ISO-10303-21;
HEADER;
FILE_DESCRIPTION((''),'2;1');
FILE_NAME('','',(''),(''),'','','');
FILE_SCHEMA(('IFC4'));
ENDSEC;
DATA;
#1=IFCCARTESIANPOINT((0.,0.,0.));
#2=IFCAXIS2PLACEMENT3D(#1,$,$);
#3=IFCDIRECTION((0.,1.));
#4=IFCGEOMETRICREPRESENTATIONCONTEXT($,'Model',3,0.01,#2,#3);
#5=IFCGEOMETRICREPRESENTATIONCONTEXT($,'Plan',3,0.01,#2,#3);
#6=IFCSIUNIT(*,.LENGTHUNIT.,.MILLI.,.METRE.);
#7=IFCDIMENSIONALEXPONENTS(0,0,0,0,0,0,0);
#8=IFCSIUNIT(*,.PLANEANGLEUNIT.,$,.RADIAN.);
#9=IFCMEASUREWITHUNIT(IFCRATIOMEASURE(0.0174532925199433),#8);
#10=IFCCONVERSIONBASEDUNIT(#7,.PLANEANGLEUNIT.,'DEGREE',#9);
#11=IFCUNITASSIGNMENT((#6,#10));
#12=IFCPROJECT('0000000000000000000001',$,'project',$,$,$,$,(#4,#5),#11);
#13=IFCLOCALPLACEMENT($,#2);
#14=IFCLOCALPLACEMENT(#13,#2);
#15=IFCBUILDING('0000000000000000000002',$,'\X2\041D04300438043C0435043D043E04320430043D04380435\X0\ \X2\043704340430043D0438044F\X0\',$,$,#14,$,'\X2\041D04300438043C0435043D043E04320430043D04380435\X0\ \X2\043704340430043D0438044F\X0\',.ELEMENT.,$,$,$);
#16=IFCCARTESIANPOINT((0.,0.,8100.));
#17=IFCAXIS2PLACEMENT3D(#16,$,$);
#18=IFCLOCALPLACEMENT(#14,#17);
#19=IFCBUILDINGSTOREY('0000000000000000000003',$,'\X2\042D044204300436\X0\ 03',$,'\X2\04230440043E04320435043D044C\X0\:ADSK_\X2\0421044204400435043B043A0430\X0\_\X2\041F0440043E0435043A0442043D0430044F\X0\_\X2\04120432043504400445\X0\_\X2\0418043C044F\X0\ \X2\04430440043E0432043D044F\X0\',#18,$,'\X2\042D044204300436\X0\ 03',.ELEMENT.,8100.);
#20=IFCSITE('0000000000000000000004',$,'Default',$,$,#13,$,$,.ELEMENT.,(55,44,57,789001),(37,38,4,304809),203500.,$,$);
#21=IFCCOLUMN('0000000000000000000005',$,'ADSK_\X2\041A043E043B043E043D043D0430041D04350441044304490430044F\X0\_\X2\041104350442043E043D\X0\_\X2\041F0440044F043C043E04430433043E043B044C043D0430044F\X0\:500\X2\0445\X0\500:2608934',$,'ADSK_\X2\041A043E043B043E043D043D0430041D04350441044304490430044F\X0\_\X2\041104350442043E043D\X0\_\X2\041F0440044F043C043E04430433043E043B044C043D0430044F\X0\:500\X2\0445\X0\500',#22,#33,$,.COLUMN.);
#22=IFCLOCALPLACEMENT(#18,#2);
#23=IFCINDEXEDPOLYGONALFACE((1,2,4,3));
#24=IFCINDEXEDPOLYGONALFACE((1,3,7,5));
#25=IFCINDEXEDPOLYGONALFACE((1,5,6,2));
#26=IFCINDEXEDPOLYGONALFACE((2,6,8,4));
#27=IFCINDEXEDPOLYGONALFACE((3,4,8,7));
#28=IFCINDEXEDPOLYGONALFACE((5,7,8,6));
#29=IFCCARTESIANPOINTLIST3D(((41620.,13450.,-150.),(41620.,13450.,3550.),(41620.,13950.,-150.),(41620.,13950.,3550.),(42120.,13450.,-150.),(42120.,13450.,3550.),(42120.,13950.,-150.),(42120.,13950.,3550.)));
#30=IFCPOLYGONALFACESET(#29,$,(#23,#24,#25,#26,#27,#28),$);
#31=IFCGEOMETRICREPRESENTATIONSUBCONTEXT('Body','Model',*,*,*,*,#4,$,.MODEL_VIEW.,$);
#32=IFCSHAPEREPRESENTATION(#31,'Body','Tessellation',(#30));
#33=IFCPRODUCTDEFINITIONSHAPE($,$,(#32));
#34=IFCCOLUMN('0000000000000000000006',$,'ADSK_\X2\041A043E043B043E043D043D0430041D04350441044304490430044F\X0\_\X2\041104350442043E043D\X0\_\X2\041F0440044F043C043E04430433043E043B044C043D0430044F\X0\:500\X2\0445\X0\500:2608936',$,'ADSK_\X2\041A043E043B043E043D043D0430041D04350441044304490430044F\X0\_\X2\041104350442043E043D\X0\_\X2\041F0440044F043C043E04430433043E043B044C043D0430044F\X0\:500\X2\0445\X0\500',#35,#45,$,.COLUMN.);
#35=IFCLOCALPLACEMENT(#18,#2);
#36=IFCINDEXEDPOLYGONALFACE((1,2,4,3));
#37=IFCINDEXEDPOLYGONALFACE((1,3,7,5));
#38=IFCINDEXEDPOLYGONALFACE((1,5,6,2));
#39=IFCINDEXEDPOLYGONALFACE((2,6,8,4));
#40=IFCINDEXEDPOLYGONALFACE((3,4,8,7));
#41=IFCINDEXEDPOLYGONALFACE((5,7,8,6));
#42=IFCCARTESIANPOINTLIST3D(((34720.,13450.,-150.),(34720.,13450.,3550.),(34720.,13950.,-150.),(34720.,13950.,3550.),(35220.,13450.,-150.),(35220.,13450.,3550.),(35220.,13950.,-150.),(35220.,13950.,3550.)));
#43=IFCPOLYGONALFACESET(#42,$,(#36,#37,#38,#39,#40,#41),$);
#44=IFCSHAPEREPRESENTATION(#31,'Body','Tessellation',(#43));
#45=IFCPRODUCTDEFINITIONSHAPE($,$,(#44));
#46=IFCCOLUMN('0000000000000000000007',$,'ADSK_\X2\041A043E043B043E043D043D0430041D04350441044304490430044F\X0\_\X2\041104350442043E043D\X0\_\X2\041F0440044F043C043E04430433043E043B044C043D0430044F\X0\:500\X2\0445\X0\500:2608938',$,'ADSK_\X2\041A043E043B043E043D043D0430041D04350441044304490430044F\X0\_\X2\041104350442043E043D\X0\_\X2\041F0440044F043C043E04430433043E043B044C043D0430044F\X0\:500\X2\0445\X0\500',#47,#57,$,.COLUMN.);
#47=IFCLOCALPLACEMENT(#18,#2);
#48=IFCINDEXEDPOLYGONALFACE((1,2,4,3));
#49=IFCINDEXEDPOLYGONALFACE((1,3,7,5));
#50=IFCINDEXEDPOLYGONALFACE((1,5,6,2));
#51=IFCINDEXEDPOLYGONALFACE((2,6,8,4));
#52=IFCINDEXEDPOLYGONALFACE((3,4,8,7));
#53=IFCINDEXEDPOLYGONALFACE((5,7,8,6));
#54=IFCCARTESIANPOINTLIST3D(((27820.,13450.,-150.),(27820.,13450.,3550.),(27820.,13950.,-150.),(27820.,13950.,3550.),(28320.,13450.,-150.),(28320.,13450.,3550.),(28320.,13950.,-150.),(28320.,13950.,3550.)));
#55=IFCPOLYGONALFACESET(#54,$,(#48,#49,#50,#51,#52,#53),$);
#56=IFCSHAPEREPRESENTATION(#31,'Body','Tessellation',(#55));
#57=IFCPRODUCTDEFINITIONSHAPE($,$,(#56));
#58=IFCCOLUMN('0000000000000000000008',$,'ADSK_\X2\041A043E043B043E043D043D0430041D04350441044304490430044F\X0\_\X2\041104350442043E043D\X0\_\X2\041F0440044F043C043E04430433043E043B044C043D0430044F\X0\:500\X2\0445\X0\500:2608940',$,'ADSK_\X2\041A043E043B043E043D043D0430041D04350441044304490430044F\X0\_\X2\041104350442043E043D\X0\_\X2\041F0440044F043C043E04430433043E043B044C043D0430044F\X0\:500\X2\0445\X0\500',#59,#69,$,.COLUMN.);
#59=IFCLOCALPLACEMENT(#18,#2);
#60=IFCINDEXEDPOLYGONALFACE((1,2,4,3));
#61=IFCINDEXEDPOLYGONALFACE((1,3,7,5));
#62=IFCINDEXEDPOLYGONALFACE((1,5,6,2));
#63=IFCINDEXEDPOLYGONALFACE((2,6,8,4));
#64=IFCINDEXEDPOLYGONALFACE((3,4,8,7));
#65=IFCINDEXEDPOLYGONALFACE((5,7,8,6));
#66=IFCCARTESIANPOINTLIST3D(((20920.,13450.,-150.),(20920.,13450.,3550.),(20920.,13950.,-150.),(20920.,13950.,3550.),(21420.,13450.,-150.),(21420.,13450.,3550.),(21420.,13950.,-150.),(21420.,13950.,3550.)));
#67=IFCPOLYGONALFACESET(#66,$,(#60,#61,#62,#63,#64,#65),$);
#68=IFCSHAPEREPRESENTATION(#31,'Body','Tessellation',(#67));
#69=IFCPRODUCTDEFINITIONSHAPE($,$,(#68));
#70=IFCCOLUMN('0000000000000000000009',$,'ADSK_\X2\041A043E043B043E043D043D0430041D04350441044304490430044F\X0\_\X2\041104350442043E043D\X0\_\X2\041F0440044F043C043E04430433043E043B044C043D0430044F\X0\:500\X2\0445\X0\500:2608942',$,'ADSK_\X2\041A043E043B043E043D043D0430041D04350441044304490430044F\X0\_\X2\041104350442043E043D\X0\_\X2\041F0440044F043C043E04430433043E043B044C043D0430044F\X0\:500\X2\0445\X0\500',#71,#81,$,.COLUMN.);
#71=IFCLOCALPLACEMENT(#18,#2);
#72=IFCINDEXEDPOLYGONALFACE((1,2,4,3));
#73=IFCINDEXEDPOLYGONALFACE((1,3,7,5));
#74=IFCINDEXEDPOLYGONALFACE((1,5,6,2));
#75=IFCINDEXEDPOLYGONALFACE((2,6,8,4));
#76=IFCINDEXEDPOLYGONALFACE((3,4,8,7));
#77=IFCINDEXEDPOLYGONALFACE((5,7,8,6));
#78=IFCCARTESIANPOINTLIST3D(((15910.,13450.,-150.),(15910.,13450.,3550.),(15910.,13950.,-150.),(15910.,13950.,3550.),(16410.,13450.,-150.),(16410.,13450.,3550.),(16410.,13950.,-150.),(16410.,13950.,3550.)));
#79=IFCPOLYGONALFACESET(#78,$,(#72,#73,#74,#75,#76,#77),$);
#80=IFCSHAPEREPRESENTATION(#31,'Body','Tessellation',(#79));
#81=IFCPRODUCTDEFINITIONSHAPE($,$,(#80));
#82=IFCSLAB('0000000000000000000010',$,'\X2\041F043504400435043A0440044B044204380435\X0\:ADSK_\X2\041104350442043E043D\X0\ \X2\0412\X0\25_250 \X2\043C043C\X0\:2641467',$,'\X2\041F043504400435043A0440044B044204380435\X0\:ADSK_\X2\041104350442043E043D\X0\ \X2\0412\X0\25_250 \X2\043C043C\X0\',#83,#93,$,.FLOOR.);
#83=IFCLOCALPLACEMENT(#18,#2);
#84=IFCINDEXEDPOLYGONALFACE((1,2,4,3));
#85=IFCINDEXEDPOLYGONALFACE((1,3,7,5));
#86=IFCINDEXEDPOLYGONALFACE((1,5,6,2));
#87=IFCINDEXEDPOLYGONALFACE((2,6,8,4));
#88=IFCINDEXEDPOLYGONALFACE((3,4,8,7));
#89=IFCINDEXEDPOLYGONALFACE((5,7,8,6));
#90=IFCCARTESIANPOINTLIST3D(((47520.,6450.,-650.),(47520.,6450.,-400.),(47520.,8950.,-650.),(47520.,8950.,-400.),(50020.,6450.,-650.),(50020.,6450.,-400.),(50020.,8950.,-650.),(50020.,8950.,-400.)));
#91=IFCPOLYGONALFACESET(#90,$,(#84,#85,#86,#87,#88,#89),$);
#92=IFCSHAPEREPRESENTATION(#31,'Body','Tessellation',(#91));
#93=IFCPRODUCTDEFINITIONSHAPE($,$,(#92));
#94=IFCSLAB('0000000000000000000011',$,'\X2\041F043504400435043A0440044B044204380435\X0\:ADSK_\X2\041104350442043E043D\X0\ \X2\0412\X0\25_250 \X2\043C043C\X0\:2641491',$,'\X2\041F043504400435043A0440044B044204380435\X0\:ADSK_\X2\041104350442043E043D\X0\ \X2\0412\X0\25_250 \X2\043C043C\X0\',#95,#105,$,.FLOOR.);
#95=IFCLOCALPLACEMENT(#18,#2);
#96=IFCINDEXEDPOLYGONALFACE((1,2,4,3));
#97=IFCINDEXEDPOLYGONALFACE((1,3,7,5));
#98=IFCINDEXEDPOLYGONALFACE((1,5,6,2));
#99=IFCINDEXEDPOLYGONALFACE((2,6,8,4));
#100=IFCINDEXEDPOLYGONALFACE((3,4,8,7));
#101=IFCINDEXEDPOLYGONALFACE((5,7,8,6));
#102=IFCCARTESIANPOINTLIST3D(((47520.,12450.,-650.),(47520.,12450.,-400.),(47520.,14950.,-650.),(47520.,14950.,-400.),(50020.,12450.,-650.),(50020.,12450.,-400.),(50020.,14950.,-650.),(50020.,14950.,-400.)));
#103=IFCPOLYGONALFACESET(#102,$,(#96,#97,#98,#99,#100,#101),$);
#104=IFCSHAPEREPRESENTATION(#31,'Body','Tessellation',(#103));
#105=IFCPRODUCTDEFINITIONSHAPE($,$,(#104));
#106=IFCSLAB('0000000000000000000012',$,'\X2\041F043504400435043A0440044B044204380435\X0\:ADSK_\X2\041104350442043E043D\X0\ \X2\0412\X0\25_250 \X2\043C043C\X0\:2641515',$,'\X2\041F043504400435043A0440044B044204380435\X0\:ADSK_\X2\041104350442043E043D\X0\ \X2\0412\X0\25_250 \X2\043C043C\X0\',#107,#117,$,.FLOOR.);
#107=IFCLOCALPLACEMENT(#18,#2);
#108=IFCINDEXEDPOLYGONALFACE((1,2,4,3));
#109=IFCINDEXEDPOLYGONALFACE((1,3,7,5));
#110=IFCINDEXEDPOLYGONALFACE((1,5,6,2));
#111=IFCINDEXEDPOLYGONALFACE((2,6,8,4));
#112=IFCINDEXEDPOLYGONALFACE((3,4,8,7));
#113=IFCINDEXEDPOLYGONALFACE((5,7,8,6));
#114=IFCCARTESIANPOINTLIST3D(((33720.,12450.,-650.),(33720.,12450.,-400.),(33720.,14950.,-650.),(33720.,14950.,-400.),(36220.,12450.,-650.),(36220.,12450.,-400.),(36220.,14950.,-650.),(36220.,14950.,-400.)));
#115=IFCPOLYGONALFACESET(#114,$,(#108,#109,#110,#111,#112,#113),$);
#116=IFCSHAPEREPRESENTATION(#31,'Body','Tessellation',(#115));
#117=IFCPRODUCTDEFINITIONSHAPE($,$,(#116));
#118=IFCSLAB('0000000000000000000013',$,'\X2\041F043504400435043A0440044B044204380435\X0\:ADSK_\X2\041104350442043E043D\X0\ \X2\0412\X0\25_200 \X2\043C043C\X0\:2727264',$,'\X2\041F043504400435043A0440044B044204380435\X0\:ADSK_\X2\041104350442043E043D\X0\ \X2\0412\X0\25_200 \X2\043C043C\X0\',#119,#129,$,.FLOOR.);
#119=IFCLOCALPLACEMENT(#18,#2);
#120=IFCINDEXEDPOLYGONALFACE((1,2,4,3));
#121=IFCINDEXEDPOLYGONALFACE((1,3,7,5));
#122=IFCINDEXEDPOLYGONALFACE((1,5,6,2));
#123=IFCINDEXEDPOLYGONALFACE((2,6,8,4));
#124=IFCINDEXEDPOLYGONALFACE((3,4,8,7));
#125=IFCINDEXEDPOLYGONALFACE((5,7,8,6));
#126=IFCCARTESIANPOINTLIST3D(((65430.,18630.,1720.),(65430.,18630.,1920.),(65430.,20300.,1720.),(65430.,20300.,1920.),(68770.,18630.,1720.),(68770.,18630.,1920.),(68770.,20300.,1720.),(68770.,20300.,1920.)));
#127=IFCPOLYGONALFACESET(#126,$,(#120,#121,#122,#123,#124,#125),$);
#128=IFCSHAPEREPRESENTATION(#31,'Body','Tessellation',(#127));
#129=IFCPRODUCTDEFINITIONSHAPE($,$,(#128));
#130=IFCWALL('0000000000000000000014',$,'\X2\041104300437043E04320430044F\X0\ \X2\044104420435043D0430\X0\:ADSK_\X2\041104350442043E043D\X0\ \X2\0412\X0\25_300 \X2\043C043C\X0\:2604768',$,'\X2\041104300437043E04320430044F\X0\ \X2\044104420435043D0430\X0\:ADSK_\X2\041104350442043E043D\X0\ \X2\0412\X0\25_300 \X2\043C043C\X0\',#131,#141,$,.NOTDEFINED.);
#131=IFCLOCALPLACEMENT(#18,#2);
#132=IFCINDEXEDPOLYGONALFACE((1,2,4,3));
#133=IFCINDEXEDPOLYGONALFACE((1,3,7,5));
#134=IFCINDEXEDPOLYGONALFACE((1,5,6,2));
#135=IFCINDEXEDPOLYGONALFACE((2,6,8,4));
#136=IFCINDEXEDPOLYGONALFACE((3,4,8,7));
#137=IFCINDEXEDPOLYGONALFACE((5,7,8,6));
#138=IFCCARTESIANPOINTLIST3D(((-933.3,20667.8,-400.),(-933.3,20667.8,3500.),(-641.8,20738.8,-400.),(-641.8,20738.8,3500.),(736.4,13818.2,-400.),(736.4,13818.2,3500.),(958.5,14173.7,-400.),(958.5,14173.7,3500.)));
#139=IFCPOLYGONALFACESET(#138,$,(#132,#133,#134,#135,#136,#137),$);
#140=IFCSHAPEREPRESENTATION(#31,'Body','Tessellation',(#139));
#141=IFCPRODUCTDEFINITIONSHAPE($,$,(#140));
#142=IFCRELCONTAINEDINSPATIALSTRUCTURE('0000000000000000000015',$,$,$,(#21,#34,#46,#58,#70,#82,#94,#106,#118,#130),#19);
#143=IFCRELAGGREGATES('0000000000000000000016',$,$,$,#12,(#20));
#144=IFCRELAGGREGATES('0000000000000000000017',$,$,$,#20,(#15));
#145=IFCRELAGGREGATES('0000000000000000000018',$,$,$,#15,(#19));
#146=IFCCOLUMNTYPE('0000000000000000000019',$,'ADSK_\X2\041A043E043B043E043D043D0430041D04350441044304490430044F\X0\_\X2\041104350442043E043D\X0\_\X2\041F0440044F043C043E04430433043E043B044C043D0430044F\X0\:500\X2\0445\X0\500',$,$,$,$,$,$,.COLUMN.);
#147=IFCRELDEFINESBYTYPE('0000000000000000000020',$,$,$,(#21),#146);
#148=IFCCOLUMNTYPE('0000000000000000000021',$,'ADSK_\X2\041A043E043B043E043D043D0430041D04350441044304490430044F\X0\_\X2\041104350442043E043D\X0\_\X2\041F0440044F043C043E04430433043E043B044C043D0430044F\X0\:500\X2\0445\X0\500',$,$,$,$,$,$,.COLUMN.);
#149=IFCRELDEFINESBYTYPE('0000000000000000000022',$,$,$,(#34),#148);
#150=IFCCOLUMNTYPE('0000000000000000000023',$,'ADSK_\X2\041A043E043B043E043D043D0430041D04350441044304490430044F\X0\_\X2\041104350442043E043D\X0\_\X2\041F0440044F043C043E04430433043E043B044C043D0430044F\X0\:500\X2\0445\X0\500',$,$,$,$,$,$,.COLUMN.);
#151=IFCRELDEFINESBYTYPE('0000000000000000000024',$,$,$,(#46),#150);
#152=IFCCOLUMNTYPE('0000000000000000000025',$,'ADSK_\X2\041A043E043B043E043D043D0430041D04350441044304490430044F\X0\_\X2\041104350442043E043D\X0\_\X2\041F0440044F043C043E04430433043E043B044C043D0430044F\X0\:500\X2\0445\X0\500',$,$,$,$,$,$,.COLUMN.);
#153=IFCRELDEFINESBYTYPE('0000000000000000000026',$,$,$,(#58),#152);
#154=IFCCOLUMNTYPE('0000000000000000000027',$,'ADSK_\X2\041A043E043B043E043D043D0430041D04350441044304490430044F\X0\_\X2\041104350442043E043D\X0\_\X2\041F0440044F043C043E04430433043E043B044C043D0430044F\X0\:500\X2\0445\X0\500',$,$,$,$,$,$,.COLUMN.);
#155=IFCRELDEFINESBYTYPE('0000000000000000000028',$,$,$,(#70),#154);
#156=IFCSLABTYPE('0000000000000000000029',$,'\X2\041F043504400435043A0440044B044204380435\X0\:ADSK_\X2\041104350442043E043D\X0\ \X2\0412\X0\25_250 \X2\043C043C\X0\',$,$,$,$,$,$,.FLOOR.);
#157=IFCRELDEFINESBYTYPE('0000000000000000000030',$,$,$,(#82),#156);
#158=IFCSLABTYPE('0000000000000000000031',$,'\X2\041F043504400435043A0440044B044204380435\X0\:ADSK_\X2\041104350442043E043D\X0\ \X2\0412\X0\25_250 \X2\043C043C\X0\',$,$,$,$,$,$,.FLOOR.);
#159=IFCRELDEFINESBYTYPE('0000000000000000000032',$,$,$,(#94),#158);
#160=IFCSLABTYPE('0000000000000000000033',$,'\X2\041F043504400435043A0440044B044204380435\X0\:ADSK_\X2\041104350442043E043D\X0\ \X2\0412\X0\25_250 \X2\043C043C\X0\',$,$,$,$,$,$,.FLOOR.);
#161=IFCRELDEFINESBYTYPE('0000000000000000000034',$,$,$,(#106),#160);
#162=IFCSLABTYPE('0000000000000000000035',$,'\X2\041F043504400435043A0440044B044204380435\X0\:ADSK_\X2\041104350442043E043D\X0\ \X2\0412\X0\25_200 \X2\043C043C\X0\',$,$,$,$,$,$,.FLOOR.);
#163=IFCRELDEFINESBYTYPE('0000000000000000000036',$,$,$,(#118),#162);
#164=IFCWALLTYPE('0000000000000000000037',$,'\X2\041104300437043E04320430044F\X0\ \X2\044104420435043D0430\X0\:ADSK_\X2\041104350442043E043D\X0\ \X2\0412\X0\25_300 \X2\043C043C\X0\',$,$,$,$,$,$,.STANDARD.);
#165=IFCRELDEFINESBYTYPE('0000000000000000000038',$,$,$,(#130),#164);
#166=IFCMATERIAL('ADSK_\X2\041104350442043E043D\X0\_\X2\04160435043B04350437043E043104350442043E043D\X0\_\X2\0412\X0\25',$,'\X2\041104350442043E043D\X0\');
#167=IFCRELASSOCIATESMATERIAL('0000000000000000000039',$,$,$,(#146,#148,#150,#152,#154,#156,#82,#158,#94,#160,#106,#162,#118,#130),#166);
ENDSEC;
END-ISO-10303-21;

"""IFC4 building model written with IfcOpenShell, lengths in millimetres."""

from ifc_helpers import new_model, entity, si_unit, converted_unit, direction, frame, origin, place, context, subcontext, project, spatial, indexed_curve, outline, extrude, source, transform, mapped, material, type_object, type_shapes, element, save


model = new_model("IFC4")

# Units and contexts
model_context = context("Model", 3, precision=0.01, world=origin(), true_north=direction((0.0, 1.0)))
plan_context = context("Plan", 3, precision=0.01, world=origin(), true_north=direction((0.0, 1.0)))
body_context = subcontext(model_context, "Body", "Model", "MODEL_VIEW")
ifc_project = project(units=[si_unit("LENGTHUNIT", "METRE", prefix="MILLI"), converted_unit("PLANEANGLEUNIT", "DEGREE", entity("IfcRatioMeasure", 0.0174532925199433), si_unit("PLANEANGLEUNIT", "RADIAN"), dimensions=[0, 0, 0, 0, 0, 0, 0])], contexts=[model_context, plan_context])

# Site, building, storey
site_placement = place(None, origin())
site = spatial("IfcSite", under=ifc_project, at=site_placement, Name="Default", CompositionType="ELEMENT", RefLatitude=(55, 44, 57, 789001), RefLongitude=(37, 38, 4, 304809), RefElevation=203500.0)
building_placement = place(site_placement, origin())
building = spatial("IfcBuilding", under=site, at=building_placement, Name="Наименование здания", LongName="Наименование здания", CompositionType="ELEMENT")
storey_placement = place(building_placement, frame((0.0, 0.0, 8100.0)))
storey = spatial("IfcBuildingStorey", under=building, at=storey_placement, Name="Этаж 03", ObjectType="Уровень:ADSK_Стрелка_Проектная_Вверх_Имя уровня", LongName="Этаж 03", CompositionType="ELEMENT", Elevation=8100.0)

# Columns
ifc_material_1 = material(Name="ADSK_Бетон_Железобетон_В25", Category="Бетон")
column_type_1 = type_object("IfcColumnType", Name="ADSK_КолоннаНесущая_Бетон_Прямоугольная:500х500", PredefinedType="COLUMN", material=ifc_material_1)
shared_shape_1 = source(origin(), body_context, "Body", "SweptSolid", [
    extrude(outline(indexed_curve([(-250.0, -250.0), (250.0, -250.0), (250.0, 250.0), (-250.0, 250.0), (-250.0, -250.0)], self_intersect=False)), frame((41870.0, 13700.0, 7950.0), z_axis=(0.0, 0.0, 1.0), x_axis=(0.0, -1.0, 0.0)), (0.0, 0.0, 1.0), 3700.0),
])
type_shapes(column_type_1, [shared_shape_1])
column_1_placement = place(storey_placement, frame((0.0, 0.0, -8100.0)))
element("IfcColumn", 1, at=column_1_placement, inside=storey, type_object=column_type_1, Name="ADSK_КолоннаНесущая_Бетон_Прямоугольная:500х500:2608934", ObjectType="ADSK_КолоннаНесущая_Бетон_Прямоугольная:500х500", PredefinedType="COLUMN", context=body_context, shape_type="MappedRepresentation", body=[
    mapped(shared_shape_1, transform((0.0, 0.0, 0.0), scale=1.0)),
])
column_type_2 = type_object("IfcColumnType", Name="ADSK_КолоннаНесущая_Бетон_Прямоугольная:500х500", PredefinedType="COLUMN", material=ifc_material_1)
shared_shape_2 = source(origin(), body_context, "Body", "SweptSolid", [
    extrude(outline(indexed_curve([(-250.0, -250.0), (250.0, -250.0), (250.0, 250.0), (-250.0, 250.0), (-250.0, -250.0)], self_intersect=False)), frame((34970.0, 13700.0, 7950.0), z_axis=(0.0, 0.0, 1.0), x_axis=(0.0, -1.0, 0.0)), (0.0, 0.0, 1.0), 3700.0),
])
type_shapes(column_type_2, [shared_shape_2])
column_2_placement = place(storey_placement, frame((0.0, 0.0, -8100.0)))
element("IfcColumn", 2, at=column_2_placement, inside=storey, type_object=column_type_2, Name="ADSK_КолоннаНесущая_Бетон_Прямоугольная:500х500:2608936", ObjectType="ADSK_КолоннаНесущая_Бетон_Прямоугольная:500х500", PredefinedType="COLUMN", context=body_context, shape_type="MappedRepresentation", body=[
    mapped(shared_shape_2, transform((0.0, 0.0, 0.0), scale=1.0)),
])
column_type_3 = type_object("IfcColumnType", Name="ADSK_КолоннаНесущая_Бетон_Прямоугольная:500х500", PredefinedType="COLUMN", material=ifc_material_1)
shared_shape_3 = source(origin(), body_context, "Body", "SweptSolid", [
    extrude(outline(indexed_curve([(-250.0, -250.0), (250.0, -250.0), (250.0, 250.0), (-250.0, 250.0), (-250.0, -250.0)], self_intersect=False)), frame((28070.0, 13700.0, 7950.0), z_axis=(0.0, 0.0, 1.0), x_axis=(0.0, -1.0, 0.0)), (0.0, 0.0, 1.0), 3700.0),
])
type_shapes(column_type_3, [shared_shape_3])
column_3_placement = place(storey_placement, frame((0.0, 0.0, -8100.0)))
element("IfcColumn", 3, at=column_3_placement, inside=storey, type_object=column_type_3, Name="ADSK_КолоннаНесущая_Бетон_Прямоугольная:500х500:2608938", ObjectType="ADSK_КолоннаНесущая_Бетон_Прямоугольная:500х500", PredefinedType="COLUMN", context=body_context, shape_type="MappedRepresentation", body=[
    mapped(shared_shape_3, transform((0.0, 0.0, 0.0), scale=1.0)),
])
column_type_4 = type_object("IfcColumnType", Name="ADSK_КолоннаНесущая_Бетон_Прямоугольная:500х500", PredefinedType="COLUMN", material=ifc_material_1)
shared_shape_4 = source(origin(), body_context, "Body", "SweptSolid", [
    extrude(outline(indexed_curve([(-250.0, -250.0), (250.0, -250.0), (250.0, 250.0), (-250.0, 250.0), (-250.0, -250.0)], self_intersect=False)), frame((21170.0, 13700.0, 7950.0), z_axis=(0.0, 0.0, 1.0), x_axis=(0.0, -1.0, 0.0)), (0.0, 0.0, 1.0), 3700.0),
])
type_shapes(column_type_4, [shared_shape_4])
column_4_placement = place(storey_placement, frame((0.0, 0.0, -8100.0)))
element("IfcColumn", 4, at=column_4_placement, inside=storey, type_object=column_type_4, Name="ADSK_КолоннаНесущая_Бетон_Прямоугольная:500х500:2608940", ObjectType="ADSK_КолоннаНесущая_Бетон_Прямоугольная:500х500", PredefinedType="COLUMN", context=body_context, shape_type="MappedRepresentation", body=[
    mapped(shared_shape_4, transform((0.0, 0.0, 0.0), scale=1.0)),
])
column_type_5 = type_object("IfcColumnType", Name="ADSK_КолоннаНесущая_Бетон_Прямоугольная:500х500", PredefinedType="COLUMN", material=ifc_material_1)
shared_shape_5 = source(origin(), body_context, "Body", "SweptSolid", [
    extrude(outline(indexed_curve([(-250.0, -250.0), (250.0, -250.0), (250.0, 250.0), (-250.0, 250.0), (-250.0, -250.0)], self_intersect=False)), frame((16160.0, 13700.0, 7950.0), z_axis=(0.0, 0.0, 1.0), x_axis=(0.0, -1.0, 0.0)), (0.0, 0.0, 1.0), 3700.0),
])
type_shapes(column_type_5, [shared_shape_5])
column_5_placement = place(storey_placement, frame((0.0, 0.0, -8100.0)))
element("IfcColumn", 5, at=column_5_placement, inside=storey, type_object=column_type_5, Name="ADSK_КолоннаНесущая_Бетон_Прямоугольная:500х500:2608942", ObjectType="ADSK_КолоннаНесущая_Бетон_Прямоугольная:500х500", PredefinedType="COLUMN", context=body_context, shape_type="MappedRepresentation", body=[
    mapped(shared_shape_5, transform((0.0, 0.0, 0.0), scale=1.0)),
])

# Slabs
slab_type_1 = type_object("IfcSlabType", Name="Перекрытие:ADSK_Бетон В25_250 мм", PredefinedType="FLOOR", material=ifc_material_1)
slab_1_placement = place(storey_placement, origin())
element("IfcSlab", 6, at=slab_1_placement, inside=storey, type_object=slab_type_1, material=ifc_material_1, Name="Перекрытие:ADSK_Бетон В25_250 мм:2641467", ObjectType="Перекрытие:ADSK_Бетон В25_250 мм", PredefinedType="FLOOR", context=body_context, shape_type="SweptSolid", body=[
    extrude(outline(indexed_curve([(-1250.0, -1250.0), (1250.0, -1250.0), (1250.0, 1250.0), (-1250.0, 1250.0), (-1250.0, -1250.0)], self_intersect=False)), frame((48770.0, 7700.0, -400.0), z_axis=(0.0, 0.0, -1.0), x_axis=(0.0, 1.0, 0.0)), (0.0, 0.0, 1.0), 250.0),
])
slab_type_2 = type_object("IfcSlabType", Name="Перекрытие:ADSK_Бетон В25_250 мм", PredefinedType="FLOOR", material=ifc_material_1)
slab_2_placement = place(storey_placement, origin())
element("IfcSlab", 7, at=slab_2_placement, inside=storey, type_object=slab_type_2, material=ifc_material_1, Name="Перекрытие:ADSK_Бетон В25_250 мм:2641491", ObjectType="Перекрытие:ADSK_Бетон В25_250 мм", PredefinedType="FLOOR", context=body_context, shape_type="SweptSolid", body=[
    extrude(outline(indexed_curve([(-1250.0, -1250.0), (1250.0, -1250.0), (1250.0, 1250.0), (-1250.0, 1250.0), (-1250.0, -1250.0)], self_intersect=False)), frame((48770.0, 13700.0, -400.0), z_axis=(0.0, 0.0, -1.0), x_axis=(0.0, 1.0, 0.0)), (0.0, 0.0, 1.0), 250.0),
])
slab_type_3 = type_object("IfcSlabType", Name="Перекрытие:ADSK_Бетон В25_250 мм", PredefinedType="FLOOR", material=ifc_material_1)
slab_3_placement = place(storey_placement, origin())
element("IfcSlab", 8, at=slab_3_placement, inside=storey, type_object=slab_type_3, material=ifc_material_1, Name="Перекрытие:ADSK_Бетон В25_250 мм:2641515", ObjectType="Перекрытие:ADSK_Бетон В25_250 мм", PredefinedType="FLOOR", context=body_context, shape_type="SweptSolid", body=[
    extrude(outline(indexed_curve([(-1250.0, -1250.0), (1250.0, -1250.0), (1250.0, 1250.0), (-1250.0, 1250.0), (-1250.0, -1250.0)], self_intersect=False)), frame((34970.0, 13700.0, -400.0), z_axis=(0.0, 0.0, -1.0), x_axis=(0.0, 1.0, 0.0)), (0.0, 0.0, 1.0), 250.0),
])
slab_type_4 = type_object("IfcSlabType", Name="Перекрытие:ADSK_Бетон В25_200 мм", PredefinedType="FLOOR", material=ifc_material_1)
slab_4_placement = place(storey_placement, origin())
element("IfcSlab", 9, at=slab_4_placement, inside=storey, type_object=slab_type_4, material=ifc_material_1, Name="Перекрытие:ADSK_Бетон В25_200 мм:2727264", ObjectType="Перекрытие:ADSK_Бетон В25_200 мм", PredefinedType="FLOOR", context=body_context, shape_type="SweptSolid", body=[
    extrude(outline(indexed_curve([(-835.0, -1670.0), (835.0, -1670.0), (835.0, 1670.0), (-835.0, 1670.0), (-835.0, -1670.0)], self_intersect=False)), frame((67100.0, 19465.0, 1920.0), z_axis=(0.0, 0.0, -1.0), x_axis=(0.0, 1.0, 0.0)), (0.0, 0.0, 1.0), 200.0),
])

# Wall
wall_type = type_object("IfcWallType", Name="Базовая стена:ADSK_Бетон В25_300 мм", PredefinedType="STANDARD")
wall_placement = place(storey_placement, frame((-787.5, 20703.3, -400.0), z_axis=(0.0, 0.0, 1.0), x_axis=(0.236826, -0.971552, 0.0)))
element("IfcWall", 10, at=wall_placement, inside=storey, type_object=wall_type, material=ifc_material_1, Name="Базовая стена:ADSK_Бетон В25_300 мм:2604768", ObjectType="Базовая стена:ADSK_Бетон В25_300 мм", PredefinedType="NOTDEFINED", context=body_context, shape_type="SweptSolid", body=[
    extrude(outline(indexed_curve([(7050.2, -150.0), (6757.4, 150.0), (0.0, 150.0), (0.0, -150.0), (7050.2, -150.0)], self_intersect=False)), origin(), (0.0, 0.0, 1.0), 3900.0),
])

save(model, "model.ifc")
